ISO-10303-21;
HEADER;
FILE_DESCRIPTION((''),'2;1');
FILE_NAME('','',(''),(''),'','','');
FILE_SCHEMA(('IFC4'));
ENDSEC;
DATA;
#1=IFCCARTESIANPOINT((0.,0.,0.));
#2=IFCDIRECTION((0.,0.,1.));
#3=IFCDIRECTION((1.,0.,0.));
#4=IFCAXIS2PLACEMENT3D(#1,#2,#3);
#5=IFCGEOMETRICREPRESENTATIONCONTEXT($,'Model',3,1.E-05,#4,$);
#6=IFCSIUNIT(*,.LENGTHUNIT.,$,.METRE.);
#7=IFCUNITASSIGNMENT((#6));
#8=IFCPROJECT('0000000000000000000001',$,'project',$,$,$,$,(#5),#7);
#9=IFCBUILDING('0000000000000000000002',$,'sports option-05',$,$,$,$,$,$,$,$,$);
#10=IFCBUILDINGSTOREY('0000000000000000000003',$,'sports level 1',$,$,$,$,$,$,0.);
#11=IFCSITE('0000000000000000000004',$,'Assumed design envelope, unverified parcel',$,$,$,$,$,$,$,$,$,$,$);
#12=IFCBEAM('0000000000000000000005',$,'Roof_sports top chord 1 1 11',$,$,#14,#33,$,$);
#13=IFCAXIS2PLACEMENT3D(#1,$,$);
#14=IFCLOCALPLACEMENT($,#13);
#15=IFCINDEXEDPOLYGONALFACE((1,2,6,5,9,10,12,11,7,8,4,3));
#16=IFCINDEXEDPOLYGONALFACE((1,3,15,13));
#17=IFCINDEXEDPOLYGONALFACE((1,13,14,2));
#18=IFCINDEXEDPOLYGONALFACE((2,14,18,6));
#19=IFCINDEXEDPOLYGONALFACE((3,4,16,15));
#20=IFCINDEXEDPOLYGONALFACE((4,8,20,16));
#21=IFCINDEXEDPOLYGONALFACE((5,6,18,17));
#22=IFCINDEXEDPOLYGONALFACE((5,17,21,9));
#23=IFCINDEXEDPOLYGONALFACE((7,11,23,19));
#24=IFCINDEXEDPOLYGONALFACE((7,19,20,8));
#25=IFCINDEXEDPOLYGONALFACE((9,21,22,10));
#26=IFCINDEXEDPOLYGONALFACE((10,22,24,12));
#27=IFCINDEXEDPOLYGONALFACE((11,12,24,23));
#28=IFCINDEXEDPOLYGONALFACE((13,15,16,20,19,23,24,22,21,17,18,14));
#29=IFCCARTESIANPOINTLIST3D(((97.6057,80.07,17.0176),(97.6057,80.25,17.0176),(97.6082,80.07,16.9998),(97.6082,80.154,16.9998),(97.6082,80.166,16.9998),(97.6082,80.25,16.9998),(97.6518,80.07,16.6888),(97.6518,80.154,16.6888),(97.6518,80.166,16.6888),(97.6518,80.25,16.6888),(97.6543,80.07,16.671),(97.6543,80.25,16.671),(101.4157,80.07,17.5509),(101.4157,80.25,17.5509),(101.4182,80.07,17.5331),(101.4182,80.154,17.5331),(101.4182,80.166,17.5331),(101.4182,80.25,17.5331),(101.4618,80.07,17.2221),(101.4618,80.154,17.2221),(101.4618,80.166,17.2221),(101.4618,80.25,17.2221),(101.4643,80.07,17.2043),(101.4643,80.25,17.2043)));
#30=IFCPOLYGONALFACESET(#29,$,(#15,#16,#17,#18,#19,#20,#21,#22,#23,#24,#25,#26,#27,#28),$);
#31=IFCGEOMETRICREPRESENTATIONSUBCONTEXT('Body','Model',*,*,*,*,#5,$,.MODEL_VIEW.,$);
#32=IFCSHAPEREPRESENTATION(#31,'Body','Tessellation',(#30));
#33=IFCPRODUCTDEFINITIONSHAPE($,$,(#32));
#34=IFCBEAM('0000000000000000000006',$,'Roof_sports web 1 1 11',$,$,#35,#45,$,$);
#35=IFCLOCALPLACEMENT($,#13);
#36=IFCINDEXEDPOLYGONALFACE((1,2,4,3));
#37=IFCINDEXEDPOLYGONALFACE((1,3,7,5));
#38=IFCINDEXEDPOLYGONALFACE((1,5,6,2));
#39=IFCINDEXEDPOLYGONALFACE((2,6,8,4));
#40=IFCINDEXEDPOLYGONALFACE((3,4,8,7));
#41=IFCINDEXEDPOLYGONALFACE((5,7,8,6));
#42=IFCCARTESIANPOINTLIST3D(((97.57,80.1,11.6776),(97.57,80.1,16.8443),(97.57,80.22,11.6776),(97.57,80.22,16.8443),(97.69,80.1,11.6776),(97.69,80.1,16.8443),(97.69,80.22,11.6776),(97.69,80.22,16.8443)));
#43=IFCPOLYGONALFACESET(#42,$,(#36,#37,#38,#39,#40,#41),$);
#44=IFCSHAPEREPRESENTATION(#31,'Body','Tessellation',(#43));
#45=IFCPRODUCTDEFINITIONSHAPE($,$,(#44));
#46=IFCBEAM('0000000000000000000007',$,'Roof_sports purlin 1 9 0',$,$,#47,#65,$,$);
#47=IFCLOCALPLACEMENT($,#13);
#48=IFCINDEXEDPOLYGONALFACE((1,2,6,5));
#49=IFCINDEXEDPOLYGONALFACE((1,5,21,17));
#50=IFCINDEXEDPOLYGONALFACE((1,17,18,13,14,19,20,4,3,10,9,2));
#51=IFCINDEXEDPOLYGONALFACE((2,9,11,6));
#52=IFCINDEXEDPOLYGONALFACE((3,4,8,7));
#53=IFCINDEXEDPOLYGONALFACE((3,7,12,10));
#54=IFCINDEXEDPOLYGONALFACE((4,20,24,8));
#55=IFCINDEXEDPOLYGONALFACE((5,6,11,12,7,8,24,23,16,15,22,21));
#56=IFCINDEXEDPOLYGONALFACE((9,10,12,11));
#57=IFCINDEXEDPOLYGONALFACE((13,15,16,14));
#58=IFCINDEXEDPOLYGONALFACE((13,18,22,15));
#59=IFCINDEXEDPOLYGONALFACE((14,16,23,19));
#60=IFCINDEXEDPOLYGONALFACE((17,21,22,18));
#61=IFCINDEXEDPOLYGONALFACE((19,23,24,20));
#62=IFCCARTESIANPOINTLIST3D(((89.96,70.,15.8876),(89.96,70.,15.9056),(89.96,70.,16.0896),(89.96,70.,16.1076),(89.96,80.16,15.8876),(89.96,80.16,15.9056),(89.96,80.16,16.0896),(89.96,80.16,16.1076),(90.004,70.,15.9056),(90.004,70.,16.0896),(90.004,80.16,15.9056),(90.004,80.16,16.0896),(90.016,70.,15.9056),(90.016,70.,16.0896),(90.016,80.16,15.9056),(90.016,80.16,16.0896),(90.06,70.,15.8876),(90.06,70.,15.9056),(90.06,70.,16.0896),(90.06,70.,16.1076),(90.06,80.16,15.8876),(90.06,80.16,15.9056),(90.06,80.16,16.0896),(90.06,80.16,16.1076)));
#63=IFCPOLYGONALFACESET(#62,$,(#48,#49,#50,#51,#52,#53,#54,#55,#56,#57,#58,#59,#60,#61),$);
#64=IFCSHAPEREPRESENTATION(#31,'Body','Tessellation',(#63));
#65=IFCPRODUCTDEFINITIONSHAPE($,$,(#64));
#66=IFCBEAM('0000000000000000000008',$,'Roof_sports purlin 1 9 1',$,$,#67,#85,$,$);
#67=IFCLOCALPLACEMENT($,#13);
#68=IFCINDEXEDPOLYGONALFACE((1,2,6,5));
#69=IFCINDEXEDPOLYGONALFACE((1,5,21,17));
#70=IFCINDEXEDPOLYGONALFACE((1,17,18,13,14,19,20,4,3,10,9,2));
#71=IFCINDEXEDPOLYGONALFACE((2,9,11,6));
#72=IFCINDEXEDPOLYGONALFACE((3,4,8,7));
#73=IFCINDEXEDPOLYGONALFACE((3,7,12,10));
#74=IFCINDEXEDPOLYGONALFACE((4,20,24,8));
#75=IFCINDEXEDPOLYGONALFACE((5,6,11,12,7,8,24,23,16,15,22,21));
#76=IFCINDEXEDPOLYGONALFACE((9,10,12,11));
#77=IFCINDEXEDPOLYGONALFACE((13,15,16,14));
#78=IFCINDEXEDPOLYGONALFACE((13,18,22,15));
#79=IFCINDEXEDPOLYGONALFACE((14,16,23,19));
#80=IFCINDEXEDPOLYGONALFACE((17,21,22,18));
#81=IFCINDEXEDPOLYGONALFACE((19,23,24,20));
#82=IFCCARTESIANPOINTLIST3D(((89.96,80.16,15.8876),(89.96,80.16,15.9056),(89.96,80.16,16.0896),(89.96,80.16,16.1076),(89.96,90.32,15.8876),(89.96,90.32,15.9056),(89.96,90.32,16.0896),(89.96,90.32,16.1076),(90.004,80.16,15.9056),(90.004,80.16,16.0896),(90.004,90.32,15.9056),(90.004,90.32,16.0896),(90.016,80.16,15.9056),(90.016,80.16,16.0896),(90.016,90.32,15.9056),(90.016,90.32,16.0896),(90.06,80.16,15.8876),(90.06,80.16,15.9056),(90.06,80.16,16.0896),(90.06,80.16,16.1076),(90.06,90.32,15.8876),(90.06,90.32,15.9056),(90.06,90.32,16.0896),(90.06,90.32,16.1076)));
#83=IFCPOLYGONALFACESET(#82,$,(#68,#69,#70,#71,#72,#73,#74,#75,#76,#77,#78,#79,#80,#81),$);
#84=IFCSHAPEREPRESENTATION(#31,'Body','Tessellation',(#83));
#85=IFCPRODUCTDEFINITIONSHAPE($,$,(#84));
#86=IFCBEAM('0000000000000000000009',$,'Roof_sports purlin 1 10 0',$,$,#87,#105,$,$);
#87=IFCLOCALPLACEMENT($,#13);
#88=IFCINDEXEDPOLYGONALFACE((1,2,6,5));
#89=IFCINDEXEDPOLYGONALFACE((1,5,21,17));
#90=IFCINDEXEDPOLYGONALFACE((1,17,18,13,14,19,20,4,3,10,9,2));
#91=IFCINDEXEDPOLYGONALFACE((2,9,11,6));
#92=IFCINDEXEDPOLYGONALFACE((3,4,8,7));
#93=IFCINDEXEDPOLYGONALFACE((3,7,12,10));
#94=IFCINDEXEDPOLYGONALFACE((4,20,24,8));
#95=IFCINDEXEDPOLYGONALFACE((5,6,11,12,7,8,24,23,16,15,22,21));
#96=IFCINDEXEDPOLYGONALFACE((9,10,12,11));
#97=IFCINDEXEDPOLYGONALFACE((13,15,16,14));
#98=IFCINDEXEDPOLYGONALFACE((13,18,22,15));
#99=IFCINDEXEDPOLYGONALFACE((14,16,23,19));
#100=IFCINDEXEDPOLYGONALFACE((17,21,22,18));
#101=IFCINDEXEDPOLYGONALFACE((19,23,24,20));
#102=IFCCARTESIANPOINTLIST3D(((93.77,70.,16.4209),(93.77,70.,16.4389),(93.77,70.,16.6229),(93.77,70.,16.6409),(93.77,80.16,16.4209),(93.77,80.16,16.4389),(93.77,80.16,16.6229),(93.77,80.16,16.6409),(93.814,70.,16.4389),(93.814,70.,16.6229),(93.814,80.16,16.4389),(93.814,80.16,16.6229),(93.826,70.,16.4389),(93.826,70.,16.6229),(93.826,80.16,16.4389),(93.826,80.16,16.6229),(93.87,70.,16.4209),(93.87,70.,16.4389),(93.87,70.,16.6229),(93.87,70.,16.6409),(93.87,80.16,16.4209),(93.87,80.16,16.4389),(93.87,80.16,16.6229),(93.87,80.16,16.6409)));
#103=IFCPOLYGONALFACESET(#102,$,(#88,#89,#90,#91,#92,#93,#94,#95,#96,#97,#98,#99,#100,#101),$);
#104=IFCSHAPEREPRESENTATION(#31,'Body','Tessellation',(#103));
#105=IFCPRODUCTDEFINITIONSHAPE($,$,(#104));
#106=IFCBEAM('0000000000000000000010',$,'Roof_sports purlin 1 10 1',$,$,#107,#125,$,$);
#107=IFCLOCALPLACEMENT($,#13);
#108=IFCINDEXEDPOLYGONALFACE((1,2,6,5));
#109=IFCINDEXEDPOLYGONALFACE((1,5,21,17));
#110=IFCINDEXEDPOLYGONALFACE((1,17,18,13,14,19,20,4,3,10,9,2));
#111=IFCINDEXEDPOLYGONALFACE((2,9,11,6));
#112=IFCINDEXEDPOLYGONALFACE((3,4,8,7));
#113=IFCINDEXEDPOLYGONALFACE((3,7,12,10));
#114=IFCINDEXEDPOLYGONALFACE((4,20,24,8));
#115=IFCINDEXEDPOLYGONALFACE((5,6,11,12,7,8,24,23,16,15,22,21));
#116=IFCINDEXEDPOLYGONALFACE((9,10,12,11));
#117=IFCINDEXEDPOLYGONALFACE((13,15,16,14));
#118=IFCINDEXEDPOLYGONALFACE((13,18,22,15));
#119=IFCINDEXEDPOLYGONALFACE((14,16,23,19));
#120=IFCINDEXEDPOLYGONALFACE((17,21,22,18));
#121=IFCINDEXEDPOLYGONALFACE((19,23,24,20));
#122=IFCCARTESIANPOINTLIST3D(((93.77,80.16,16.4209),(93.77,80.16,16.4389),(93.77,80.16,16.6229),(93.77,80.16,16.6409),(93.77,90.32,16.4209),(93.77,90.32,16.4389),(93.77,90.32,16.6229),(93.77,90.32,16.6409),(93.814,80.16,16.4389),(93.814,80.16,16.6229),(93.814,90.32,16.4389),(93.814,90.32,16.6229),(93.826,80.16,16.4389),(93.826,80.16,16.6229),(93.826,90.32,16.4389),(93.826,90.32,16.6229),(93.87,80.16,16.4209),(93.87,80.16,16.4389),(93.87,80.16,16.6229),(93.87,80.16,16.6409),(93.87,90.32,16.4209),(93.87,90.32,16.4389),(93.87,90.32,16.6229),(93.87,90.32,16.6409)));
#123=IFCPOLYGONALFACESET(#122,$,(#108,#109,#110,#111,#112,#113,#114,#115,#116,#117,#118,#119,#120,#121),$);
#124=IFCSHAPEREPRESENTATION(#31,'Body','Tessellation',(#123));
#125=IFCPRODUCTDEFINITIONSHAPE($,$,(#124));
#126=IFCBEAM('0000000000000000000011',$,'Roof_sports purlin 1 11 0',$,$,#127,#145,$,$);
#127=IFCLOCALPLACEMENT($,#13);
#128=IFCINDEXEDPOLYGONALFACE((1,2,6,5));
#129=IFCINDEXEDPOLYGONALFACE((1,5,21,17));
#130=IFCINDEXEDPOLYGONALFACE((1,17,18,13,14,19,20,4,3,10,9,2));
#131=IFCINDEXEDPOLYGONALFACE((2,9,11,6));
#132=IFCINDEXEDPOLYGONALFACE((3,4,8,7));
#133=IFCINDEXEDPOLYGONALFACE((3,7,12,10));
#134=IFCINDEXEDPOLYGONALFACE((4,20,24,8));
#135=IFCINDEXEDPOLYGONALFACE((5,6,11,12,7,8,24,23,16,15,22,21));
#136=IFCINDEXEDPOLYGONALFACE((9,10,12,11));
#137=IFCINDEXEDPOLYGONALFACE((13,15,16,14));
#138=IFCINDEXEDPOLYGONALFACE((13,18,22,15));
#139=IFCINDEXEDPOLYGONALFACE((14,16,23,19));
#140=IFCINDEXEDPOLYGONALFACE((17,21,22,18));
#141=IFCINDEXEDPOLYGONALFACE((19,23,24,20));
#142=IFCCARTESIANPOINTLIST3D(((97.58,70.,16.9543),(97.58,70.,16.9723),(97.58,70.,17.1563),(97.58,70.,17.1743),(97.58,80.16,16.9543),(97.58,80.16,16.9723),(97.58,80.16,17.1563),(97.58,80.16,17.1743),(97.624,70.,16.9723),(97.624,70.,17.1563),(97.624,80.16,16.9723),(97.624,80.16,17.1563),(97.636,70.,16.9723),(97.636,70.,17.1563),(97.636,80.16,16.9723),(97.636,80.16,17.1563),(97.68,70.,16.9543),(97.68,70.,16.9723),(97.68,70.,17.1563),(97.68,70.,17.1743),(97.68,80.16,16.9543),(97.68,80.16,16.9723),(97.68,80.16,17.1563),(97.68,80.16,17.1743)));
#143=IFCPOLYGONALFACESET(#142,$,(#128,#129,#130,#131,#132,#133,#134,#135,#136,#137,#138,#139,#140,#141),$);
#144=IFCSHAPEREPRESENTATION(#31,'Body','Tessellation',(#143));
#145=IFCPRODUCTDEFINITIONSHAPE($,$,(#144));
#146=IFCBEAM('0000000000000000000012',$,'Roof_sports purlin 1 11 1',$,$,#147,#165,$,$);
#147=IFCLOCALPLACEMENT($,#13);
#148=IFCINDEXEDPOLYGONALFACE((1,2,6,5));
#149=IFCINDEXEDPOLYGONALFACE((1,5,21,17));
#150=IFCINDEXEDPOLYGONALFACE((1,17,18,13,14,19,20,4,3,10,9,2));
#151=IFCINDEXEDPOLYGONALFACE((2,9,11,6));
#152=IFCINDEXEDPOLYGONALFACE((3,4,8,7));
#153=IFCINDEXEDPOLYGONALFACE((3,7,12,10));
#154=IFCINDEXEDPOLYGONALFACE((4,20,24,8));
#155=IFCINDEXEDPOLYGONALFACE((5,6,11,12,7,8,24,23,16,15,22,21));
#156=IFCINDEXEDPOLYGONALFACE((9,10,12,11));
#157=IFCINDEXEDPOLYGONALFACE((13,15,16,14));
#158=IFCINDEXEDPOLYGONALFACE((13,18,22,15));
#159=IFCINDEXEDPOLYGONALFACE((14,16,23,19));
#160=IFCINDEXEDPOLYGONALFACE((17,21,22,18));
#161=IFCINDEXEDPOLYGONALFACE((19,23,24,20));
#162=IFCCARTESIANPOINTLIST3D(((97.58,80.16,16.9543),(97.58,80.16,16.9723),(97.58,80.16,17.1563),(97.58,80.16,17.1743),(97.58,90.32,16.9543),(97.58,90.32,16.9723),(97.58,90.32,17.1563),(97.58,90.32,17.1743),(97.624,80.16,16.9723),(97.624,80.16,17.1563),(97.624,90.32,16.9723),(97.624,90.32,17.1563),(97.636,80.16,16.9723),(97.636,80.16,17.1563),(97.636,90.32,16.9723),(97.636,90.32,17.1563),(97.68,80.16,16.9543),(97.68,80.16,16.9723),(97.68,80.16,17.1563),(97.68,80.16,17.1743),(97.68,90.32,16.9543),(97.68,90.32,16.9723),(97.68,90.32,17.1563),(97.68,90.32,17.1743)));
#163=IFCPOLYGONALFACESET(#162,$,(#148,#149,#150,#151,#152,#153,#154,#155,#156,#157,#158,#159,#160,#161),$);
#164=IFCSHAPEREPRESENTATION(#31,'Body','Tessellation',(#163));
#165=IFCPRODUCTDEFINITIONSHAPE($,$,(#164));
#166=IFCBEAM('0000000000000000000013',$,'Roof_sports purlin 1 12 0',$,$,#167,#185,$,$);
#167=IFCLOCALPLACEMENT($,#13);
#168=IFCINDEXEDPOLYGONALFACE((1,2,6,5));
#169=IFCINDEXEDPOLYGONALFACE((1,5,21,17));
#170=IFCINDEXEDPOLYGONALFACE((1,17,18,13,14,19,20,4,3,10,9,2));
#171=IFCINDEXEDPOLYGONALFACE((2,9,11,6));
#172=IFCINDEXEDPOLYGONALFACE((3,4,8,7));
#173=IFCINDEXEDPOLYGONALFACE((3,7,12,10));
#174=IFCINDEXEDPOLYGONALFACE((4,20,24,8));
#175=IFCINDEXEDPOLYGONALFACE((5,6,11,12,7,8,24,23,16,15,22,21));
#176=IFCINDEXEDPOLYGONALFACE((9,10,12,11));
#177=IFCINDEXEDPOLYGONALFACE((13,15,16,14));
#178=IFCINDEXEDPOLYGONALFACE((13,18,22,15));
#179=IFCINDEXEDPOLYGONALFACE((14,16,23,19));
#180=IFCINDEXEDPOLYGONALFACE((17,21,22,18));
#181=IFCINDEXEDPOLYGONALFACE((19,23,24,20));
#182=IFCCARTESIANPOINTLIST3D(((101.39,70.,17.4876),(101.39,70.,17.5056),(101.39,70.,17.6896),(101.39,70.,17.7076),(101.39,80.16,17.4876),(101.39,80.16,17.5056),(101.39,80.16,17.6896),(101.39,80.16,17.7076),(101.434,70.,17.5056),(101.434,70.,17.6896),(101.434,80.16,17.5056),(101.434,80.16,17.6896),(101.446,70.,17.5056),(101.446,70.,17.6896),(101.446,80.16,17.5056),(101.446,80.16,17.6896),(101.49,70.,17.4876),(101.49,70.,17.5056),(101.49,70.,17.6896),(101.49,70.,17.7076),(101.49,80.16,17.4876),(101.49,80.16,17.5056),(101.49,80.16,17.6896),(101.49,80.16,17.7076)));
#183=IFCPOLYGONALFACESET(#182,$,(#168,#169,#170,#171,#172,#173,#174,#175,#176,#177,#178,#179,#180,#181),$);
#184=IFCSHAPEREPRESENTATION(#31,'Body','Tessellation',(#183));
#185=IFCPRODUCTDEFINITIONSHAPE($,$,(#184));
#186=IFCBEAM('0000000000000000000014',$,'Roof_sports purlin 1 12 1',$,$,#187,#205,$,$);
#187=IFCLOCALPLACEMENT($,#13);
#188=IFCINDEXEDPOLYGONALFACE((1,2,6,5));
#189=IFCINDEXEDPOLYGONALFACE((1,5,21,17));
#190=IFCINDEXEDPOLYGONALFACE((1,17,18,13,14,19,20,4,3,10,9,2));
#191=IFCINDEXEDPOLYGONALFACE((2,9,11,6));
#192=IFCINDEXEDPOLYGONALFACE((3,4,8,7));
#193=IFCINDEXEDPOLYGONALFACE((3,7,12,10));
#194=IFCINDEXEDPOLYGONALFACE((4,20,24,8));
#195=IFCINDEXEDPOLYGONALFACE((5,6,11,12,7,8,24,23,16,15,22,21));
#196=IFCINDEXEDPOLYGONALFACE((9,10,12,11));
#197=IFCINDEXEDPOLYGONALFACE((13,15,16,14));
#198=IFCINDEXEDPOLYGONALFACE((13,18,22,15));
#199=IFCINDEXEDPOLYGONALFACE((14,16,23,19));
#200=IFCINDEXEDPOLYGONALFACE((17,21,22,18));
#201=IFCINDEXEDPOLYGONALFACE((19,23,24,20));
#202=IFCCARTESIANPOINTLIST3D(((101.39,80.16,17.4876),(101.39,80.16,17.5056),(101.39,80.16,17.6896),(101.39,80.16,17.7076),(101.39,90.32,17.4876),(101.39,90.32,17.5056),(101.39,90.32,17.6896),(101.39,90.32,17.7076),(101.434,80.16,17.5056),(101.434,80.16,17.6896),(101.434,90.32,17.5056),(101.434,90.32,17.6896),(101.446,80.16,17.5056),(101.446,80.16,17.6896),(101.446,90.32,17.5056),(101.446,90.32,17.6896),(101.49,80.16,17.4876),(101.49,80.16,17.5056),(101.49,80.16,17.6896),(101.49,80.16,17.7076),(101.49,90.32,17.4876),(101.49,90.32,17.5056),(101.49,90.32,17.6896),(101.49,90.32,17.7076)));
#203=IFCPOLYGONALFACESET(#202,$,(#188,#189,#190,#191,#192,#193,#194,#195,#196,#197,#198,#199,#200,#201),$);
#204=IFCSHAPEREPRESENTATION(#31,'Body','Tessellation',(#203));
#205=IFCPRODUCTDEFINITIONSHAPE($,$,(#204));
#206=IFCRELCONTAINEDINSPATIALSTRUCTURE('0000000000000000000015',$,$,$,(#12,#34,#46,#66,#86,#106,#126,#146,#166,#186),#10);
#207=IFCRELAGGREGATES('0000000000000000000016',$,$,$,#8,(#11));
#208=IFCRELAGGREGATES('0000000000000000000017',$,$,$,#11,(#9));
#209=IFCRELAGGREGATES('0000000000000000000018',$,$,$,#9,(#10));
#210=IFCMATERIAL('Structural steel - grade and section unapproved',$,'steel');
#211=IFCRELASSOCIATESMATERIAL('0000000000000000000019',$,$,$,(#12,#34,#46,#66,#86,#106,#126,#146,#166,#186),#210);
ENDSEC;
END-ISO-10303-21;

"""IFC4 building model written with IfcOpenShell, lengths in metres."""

from ifc_helpers import new_model, si_unit, frame, origin_with_axes, place, context, subcontext, project, spatial, rectangle, i_section, extrude, material, element, save


model = new_model("IFC4")

# Units and contexts
model_context = context("Model", 3, precision=1e-05, world=origin_with_axes())
body_context = subcontext(model_context, "Body", "Model", "MODEL_VIEW")
ifc_project = project(units=[si_unit("LENGTHUNIT", "METRE")], contexts=[model_context])

# Site, building, storey
site = spatial("IfcSite", under=ifc_project, Name="Assumed design envelope, unverified parcel")
building = spatial("IfcBuilding", under=site, Name="sports option-05")
storey = spatial("IfcBuildingStorey", under=building, Name="sports level 1", Elevation=0.0)

# Shared definitions
ifc_material_1 = material(Name="Structural steel - grade and section unapproved", Category="steel")

# Beams
beam_1_placement = place(None, frame((97.63, 80.16, 16.8443), z_axis=(0.990344, 0.0, 0.138631), x_axis=(0.0, 1.0, 0.0)))
element("IfcBeam", 1, at=beam_1_placement, inside=storey, material=ifc_material_1, Name="Roof_sports top chord 1 1 11", context=body_context, shape_type="SweptSolid", body=[
    extrude(i_section(OverallWidth=0.18, OverallDepth=0.35, WebThickness=0.012, FlangeThickness=0.018, FilletRadius=0.0), origin_with_axes(), (0.0, 0.0, 1.0), 3.8472),
])
beam_2_placement = place(None, frame((97.63, 80.16, 11.6776), z_axis=(0.0, 0.0, 1.0), x_axis=(-1.0, 0.0, 0.0)))
element("IfcBeam", 2, at=beam_2_placement, inside=storey, material=ifc_material_1, Name="Roof_sports web 1 1 11", context=body_context, shape_type="SweptSolid", body=[
    extrude(rectangle(XDim=0.12, YDim=0.12), origin_with_axes(), (0.0, 0.0, 1.0), 5.1667),
])
beam_3_placement = place(None, frame((90.01, 70.0, 15.9976), z_axis=(0.0, 1.0, 0.0), x_axis=(-1.0, 0.0, 0.0)))
element("IfcBeam", 3, at=beam_3_placement, inside=storey, material=ifc_material_1, Name="Roof_sports purlin 1 9 0", context=body_context, shape_type="SweptSolid", body=[
    extrude(i_section(OverallWidth=0.1, OverallDepth=0.22, WebThickness=0.012, FlangeThickness=0.018, FilletRadius=0.0), origin_with_axes(), (0.0, 0.0, 1.0), 10.16),
])
beam_4_placement = place(None, frame((90.01, 80.16, 15.9976), z_axis=(0.0, 1.0, 0.0), x_axis=(-1.0, 0.0, 0.0)))
element("IfcBeam", 4, at=beam_4_placement, inside=storey, material=ifc_material_1, Name="Roof_sports purlin 1 9 1", context=body_context, shape_type="SweptSolid", body=[
    extrude(i_section(OverallWidth=0.1, OverallDepth=0.22, WebThickness=0.012, FlangeThickness=0.018, FilletRadius=0.0), origin_with_axes(), (0.0, 0.0, 1.0), 10.16),
])
beam_5_placement = place(None, frame((93.82, 70.0, 16.5309), z_axis=(0.0, 1.0, 0.0), x_axis=(-1.0, 0.0, 0.0)))
element("IfcBeam", 5, at=beam_5_placement, inside=storey, material=ifc_material_1, Name="Roof_sports purlin 1 10 0", context=body_context, shape_type="SweptSolid", body=[
    extrude(i_section(OverallWidth=0.1, OverallDepth=0.22, WebThickness=0.012, FlangeThickness=0.018, FilletRadius=0.0), origin_with_axes(), (0.0, 0.0, 1.0), 10.16),
])
beam_6_placement = place(None, frame((93.82, 80.16, 16.5309), z_axis=(0.0, 1.0, 0.0), x_axis=(-1.0, 0.0, 0.0)))
element("IfcBeam", 6, at=beam_6_placement, inside=storey, material=ifc_material_1, Name="Roof_sports purlin 1 10 1", context=body_context, shape_type="SweptSolid", body=[
    extrude(i_section(OverallWidth=0.1, OverallDepth=0.22, WebThickness=0.012, FlangeThickness=0.018, FilletRadius=0.0), origin_with_axes(), (0.0, 0.0, 1.0), 10.16),
])
beam_7_placement = place(None, frame((97.63, 70.0, 17.0643), z_axis=(0.0, 1.0, 0.0), x_axis=(-1.0, 0.0, 0.0)))
element("IfcBeam", 7, at=beam_7_placement, inside=storey, material=ifc_material_1, Name="Roof_sports purlin 1 11 0", context=body_context, shape_type="SweptSolid", body=[
    extrude(i_section(OverallWidth=0.1, OverallDepth=0.22, WebThickness=0.012, FlangeThickness=0.018, FilletRadius=0.0), origin_with_axes(), (0.0, 0.0, 1.0), 10.16),
])
beam_8_placement = place(None, frame((97.63, 80.16, 17.0643), z_axis=(0.0, 1.0, 0.0), x_axis=(-1.0, 0.0, 0.0)))
element("IfcBeam", 8, at=beam_8_placement, inside=storey, material=ifc_material_1, Name="Roof_sports purlin 1 11 1", context=body_context, shape_type="SweptSolid", body=[
    extrude(i_section(OverallWidth=0.1, OverallDepth=0.22, WebThickness=0.012, FlangeThickness=0.018, FilletRadius=0.0), origin_with_axes(), (0.0, 0.0, 1.0), 10.16),
])
beam_9_placement = place(None, frame((101.44, 70.0, 17.5976), z_axis=(0.0, 1.0, 0.0), x_axis=(-1.0, 0.0, 0.0)))
element("IfcBeam", 9, at=beam_9_placement, inside=storey, material=ifc_material_1, Name="Roof_sports purlin 1 12 0", context=body_context, shape_type="SweptSolid", body=[
    extrude(i_section(OverallWidth=0.1, OverallDepth=0.22, WebThickness=0.012, FlangeThickness=0.018, FilletRadius=0.0), origin_with_axes(), (0.0, 0.0, 1.0), 10.16),
])
beam_10_placement = place(None, frame((101.44, 80.16, 17.5976), z_axis=(0.0, 1.0, 0.0), x_axis=(-1.0, 0.0, 0.0)))
element("IfcBeam", 10, at=beam_10_placement, inside=storey, material=ifc_material_1, Name="Roof_sports purlin 1 12 1", context=body_context, shape_type="SweptSolid", body=[
    extrude(i_section(OverallWidth=0.1, OverallDepth=0.22, WebThickness=0.012, FlangeThickness=0.018, FilletRadius=0.0), origin_with_axes(), (0.0, 0.0, 1.0), 10.16),
])

save(model, "model.ifc")
